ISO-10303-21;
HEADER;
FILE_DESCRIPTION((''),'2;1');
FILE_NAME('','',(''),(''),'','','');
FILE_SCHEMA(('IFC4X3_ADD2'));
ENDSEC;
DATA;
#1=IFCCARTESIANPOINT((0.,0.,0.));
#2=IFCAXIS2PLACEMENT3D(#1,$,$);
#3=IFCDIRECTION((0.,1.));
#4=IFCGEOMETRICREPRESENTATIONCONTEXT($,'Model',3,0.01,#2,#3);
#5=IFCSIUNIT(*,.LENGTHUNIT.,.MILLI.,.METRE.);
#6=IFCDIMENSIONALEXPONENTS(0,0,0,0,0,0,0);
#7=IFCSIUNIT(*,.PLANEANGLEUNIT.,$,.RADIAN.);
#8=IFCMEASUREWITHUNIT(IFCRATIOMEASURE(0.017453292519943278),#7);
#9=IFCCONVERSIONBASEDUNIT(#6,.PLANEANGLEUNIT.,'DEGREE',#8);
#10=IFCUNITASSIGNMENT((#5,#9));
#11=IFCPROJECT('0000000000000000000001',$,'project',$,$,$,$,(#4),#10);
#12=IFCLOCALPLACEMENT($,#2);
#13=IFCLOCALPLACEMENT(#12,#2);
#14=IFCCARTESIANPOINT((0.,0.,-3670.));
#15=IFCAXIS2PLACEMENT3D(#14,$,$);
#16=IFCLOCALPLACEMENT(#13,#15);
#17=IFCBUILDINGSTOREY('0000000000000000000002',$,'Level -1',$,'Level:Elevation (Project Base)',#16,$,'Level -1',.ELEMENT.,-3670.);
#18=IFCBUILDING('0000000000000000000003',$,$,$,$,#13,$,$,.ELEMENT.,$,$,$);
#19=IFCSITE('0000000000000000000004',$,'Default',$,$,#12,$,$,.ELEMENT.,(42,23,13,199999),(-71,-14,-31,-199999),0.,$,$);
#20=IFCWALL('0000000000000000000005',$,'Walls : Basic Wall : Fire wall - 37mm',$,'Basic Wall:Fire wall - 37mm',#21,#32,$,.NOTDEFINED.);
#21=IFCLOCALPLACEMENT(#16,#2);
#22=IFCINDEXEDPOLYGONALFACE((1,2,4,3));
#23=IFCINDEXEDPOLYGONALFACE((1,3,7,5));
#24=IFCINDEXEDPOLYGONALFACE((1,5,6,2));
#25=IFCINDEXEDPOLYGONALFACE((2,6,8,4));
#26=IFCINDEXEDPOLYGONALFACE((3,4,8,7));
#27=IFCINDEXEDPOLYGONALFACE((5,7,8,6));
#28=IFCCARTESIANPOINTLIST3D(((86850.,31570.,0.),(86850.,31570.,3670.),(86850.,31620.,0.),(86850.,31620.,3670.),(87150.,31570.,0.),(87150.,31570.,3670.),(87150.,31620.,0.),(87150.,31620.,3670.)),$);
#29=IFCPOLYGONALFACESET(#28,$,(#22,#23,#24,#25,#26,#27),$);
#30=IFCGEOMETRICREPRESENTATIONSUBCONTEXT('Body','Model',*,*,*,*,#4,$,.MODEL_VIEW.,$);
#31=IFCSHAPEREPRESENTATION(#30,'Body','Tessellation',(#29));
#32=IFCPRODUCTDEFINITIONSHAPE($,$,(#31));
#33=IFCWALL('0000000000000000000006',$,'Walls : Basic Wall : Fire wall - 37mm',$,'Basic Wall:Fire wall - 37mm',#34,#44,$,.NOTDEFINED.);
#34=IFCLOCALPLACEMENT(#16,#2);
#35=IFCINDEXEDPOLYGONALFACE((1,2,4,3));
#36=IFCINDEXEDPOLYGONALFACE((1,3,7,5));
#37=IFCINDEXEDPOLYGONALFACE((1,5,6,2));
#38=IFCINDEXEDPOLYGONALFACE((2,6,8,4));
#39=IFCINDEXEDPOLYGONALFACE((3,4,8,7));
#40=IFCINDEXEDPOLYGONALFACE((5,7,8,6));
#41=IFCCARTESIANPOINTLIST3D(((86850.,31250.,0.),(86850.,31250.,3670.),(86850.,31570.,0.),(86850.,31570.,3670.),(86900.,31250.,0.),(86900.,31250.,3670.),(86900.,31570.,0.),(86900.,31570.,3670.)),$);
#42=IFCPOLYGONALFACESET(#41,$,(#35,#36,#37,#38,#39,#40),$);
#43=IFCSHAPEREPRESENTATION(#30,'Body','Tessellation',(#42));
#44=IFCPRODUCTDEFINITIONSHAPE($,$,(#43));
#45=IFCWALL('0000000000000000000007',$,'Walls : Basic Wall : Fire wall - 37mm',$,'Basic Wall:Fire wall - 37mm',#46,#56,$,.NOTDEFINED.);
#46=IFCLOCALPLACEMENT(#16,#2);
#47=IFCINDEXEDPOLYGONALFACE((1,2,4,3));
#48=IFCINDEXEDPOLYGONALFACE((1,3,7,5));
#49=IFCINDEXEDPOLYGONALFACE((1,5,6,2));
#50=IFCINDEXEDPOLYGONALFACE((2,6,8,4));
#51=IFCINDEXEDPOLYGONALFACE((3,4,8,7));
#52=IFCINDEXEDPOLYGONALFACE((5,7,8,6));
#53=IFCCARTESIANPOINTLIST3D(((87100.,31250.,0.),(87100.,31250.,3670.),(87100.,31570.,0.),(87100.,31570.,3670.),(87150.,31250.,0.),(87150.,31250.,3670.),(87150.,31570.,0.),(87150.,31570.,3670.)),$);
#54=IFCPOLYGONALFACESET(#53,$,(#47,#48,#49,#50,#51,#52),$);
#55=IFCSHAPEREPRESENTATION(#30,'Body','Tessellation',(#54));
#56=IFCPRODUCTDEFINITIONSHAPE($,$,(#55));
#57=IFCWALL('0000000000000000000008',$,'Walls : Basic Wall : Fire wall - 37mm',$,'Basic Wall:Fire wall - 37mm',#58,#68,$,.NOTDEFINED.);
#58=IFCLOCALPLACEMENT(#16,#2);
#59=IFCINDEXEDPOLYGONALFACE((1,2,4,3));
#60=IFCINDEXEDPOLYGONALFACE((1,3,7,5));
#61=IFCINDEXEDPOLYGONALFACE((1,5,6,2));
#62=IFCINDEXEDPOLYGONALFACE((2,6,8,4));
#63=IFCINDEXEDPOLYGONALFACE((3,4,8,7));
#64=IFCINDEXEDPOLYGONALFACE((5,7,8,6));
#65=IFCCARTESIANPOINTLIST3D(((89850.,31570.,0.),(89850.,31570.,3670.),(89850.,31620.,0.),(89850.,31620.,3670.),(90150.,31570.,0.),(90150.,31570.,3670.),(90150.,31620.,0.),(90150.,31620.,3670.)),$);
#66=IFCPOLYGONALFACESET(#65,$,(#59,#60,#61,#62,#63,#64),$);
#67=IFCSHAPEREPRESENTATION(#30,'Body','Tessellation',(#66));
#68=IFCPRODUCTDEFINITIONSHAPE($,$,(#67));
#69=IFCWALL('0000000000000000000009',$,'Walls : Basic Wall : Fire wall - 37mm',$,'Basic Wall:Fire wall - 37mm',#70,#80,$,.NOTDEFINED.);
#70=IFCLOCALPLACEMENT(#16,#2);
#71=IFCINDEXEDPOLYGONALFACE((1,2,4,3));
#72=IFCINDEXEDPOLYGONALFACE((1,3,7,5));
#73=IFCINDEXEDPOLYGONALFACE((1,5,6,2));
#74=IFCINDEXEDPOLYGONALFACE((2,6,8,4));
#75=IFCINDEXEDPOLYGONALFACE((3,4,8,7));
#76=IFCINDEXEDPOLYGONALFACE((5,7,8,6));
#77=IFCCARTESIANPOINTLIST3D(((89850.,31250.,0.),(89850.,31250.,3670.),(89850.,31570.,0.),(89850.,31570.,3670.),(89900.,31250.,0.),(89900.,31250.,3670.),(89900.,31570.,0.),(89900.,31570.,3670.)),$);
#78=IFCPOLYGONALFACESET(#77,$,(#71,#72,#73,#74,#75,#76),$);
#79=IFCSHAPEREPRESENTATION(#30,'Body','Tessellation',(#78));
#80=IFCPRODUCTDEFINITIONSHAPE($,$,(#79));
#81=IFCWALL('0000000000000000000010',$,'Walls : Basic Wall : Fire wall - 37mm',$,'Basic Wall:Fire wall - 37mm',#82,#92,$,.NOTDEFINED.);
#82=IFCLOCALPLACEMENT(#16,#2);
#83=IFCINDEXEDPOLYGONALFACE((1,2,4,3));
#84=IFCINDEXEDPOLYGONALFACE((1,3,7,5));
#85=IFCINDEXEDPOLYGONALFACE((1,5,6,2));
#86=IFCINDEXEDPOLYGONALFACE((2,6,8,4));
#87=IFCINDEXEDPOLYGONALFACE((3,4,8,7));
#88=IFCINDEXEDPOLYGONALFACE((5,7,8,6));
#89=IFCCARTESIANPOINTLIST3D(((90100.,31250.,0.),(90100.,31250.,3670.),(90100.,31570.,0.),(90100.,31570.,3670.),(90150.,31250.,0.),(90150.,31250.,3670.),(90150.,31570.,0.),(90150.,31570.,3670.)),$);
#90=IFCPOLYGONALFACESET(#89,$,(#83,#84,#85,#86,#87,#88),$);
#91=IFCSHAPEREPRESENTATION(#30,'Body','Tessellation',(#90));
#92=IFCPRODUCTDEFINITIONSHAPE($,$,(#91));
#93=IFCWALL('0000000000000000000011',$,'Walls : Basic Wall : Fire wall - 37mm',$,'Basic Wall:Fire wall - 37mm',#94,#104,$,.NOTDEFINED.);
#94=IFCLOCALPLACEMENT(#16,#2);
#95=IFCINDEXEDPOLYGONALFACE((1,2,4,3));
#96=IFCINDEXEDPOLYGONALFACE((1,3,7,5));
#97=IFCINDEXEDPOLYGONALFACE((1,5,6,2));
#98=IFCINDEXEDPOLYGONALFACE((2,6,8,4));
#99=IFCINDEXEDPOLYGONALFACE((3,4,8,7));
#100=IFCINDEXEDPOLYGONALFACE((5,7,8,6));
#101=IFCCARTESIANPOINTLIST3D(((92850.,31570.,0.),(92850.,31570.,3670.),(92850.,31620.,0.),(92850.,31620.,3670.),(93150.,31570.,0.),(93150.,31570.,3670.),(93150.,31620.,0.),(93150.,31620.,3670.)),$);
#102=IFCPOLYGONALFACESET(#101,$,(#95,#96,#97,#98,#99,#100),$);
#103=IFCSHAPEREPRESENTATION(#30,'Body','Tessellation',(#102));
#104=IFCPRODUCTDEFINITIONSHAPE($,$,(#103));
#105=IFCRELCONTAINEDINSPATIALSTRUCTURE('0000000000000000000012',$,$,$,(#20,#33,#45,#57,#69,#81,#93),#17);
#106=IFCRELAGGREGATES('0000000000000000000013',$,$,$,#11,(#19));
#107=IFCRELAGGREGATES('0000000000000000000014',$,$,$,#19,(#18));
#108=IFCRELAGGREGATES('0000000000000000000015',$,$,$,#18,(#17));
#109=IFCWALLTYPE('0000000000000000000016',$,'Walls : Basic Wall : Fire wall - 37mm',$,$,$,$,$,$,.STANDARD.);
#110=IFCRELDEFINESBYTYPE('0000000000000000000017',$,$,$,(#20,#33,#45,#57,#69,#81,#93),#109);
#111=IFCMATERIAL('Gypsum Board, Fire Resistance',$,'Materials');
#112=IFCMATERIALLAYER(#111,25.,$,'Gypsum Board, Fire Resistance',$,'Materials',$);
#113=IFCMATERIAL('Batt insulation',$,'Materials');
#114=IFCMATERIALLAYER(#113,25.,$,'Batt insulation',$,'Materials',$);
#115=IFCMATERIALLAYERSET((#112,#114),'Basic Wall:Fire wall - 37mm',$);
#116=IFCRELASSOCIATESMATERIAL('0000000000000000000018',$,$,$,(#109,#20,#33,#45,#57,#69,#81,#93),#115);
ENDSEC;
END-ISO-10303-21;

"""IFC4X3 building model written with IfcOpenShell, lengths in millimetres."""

from ifc_helpers import new_model, entity, si_unit, converted_unit, direction, frame, frame_2d, origin, place, context, subcontext, project, spatial, rectangle, extrude, material, layer, layer_set, type_object, element, save


model = new_model("IFC4X3")

# Units and contexts
model_context = context("Model", 3, precision=0.01, world=origin(), true_north=direction((0.0, 1.0)))
body_context = subcontext(model_context, "Body", "Model", "MODEL_VIEW")
ifc_project = project(units=[si_unit("LENGTHUNIT", "METRE", prefix="MILLI"), converted_unit("PLANEANGLEUNIT", "DEGREE", entity("IfcRatioMeasure", 0.017453292519943278), si_unit("PLANEANGLEUNIT", "RADIAN"), dimensions=[0, 0, 0, 0, 0, 0, 0])], contexts=[model_context])

# Site, building, storey
site_placement = place(None, origin())
site = spatial("IfcSite", under=ifc_project, at=site_placement, Name="Default", CompositionType="ELEMENT", RefLatitude=(42, 23, 13, 199999), RefLongitude=(-71, -14, -31, -199999), RefElevation=0.0)
building_placement = place(site_placement, origin())
building = spatial("IfcBuilding", under=site, at=building_placement, CompositionType="ELEMENT")
storey_placement = place(building_placement, frame((0.0, 0.0, -3670.0)))
storey = spatial("IfcBuildingStorey", under=building, at=storey_placement, Name="Level -1", ObjectType="Level:Elevation (Project Base)", LongName="Level -1", CompositionType="ELEMENT", Elevation=-3670.0)

# Walls
ifc_material_1 = material(Name="Gypsum Board, Fire Resistance", Category="Materials")
ifc_layer_1 = layer(ifc_material_1, 25.0, Name="Gypsum Board, Fire Resistance", Category="Materials")
ifc_material_2 = material(Name="Batt insulation", Category="Materials")
ifc_layer_2 = layer(ifc_material_2, 25.0, Name="Batt insulation", Category="Materials")
ifc_layer_set = layer_set([ifc_layer_1, ifc_layer_2], Name="Basic Wall:Fire wall - 37mm")
wall_type = type_object("IfcWallType", Name="Walls : Basic Wall : Fire wall - 37mm", PredefinedType="STANDARD", material=ifc_layer_set)
wall_1_placement = place(storey_placement, frame((86850.0, 31595.0, 0.0)))
element("IfcWall", 1, at=wall_1_placement, inside=storey, type_object=wall_type, material=ifc_layer_set, Name="Walls : Basic Wall : Fire wall - 37mm", ObjectType="Basic Wall:Fire wall - 37mm", PredefinedType="NOTDEFINED", context=body_context, shape_type="SweptSolid", body=[
    extrude(rectangle(XDim=300.0, YDim=50.0, at=frame_2d((150.0, 0.0), x_axis=(-1.0, 0.0))), origin(), (0.0, 0.0, 1.0), 3670.0),
])
for number, where, z_axis, x_axis, name in (
    (2, (86875.0, 31570.0, 0.0), (0.0, 0.0, 1.0), (0.0, -1.0, 0.0), "Walls : Basic Wall : Fire wall - 37mm"),
    (3, (87125.0, 31570.0, 0.0), (0.0, 0.0, 1.0), (0.0, -1.0, 0.0), "Walls : Basic Wall : Fire wall - 37mm"),
):
    element("IfcWall", number, at=place(storey_placement, frame(where, z_axis=z_axis, x_axis=x_axis)), inside=storey, type_object=wall_type, material=ifc_layer_set, Name=name, ObjectType="Basic Wall:Fire wall - 37mm", PredefinedType="NOTDEFINED", context=body_context, shape_type="SweptSolid", body=[
        extrude(rectangle(XDim=320.0, YDim=50.0, at=frame_2d((160.0, 0.0), x_axis=(-1.0, 0.0))), origin(), (0.0, 0.0, 1.0), 3670.0),
    ])
wall_2_placement = place(storey_placement, frame((89850.0, 31595.0, 0.0)))
element("IfcWall", 4, at=wall_2_placement, inside=storey, type_object=wall_type, material=ifc_layer_set, Name="Walls : Basic Wall : Fire wall - 37mm", ObjectType="Basic Wall:Fire wall - 37mm", PredefinedType="NOTDEFINED", context=body_context, shape_type="SweptSolid", body=[
    extrude(rectangle(XDim=300.0, YDim=50.0, at=frame_2d((150.0, 0.0), x_axis=(-1.0, 0.0))), origin(), (0.0, 0.0, 1.0), 3670.0),
])
for number, where, z_axis, x_axis, name in (
    (5, (89875.0, 31570.0, 0.0), (0.0, 0.0, 1.0), (0.0, -1.0, 0.0), "Walls : Basic Wall : Fire wall - 37mm"),
    (6, (90125.0, 31570.0, 0.0), (0.0, 0.0, 1.0), (0.0, -1.0, 0.0), "Walls : Basic Wall : Fire wall - 37mm"),
):
    element("IfcWall", number, at=place(storey_placement, frame(where, z_axis=z_axis, x_axis=x_axis)), inside=storey, type_object=wall_type, material=ifc_layer_set, Name=name, ObjectType="Basic Wall:Fire wall - 37mm", PredefinedType="NOTDEFINED", context=body_context, shape_type="SweptSolid", body=[
        extrude(rectangle(XDim=320.0, YDim=50.0, at=frame_2d((160.0, 0.0), x_axis=(-1.0, 0.0))), origin(), (0.0, 0.0, 1.0), 3670.0),
    ])
wall_3_placement = place(storey_placement, frame((92850.0, 31595.0, 0.0)))
element("IfcWall", 7, at=wall_3_placement, inside=storey, type_object=wall_type, material=ifc_layer_set, Name="Walls : Basic Wall : Fire wall - 37mm", ObjectType="Basic Wall:Fire wall - 37mm", PredefinedType="NOTDEFINED", context=body_context, shape_type="SweptSolid", body=[
    extrude(rectangle(XDim=300.0, YDim=50.0, at=frame_2d((150.0, 0.0), x_axis=(-1.0, 0.0))), origin(), (0.0, 0.0, 1.0), 3670.0),
])

save(model, "model.ifc")
